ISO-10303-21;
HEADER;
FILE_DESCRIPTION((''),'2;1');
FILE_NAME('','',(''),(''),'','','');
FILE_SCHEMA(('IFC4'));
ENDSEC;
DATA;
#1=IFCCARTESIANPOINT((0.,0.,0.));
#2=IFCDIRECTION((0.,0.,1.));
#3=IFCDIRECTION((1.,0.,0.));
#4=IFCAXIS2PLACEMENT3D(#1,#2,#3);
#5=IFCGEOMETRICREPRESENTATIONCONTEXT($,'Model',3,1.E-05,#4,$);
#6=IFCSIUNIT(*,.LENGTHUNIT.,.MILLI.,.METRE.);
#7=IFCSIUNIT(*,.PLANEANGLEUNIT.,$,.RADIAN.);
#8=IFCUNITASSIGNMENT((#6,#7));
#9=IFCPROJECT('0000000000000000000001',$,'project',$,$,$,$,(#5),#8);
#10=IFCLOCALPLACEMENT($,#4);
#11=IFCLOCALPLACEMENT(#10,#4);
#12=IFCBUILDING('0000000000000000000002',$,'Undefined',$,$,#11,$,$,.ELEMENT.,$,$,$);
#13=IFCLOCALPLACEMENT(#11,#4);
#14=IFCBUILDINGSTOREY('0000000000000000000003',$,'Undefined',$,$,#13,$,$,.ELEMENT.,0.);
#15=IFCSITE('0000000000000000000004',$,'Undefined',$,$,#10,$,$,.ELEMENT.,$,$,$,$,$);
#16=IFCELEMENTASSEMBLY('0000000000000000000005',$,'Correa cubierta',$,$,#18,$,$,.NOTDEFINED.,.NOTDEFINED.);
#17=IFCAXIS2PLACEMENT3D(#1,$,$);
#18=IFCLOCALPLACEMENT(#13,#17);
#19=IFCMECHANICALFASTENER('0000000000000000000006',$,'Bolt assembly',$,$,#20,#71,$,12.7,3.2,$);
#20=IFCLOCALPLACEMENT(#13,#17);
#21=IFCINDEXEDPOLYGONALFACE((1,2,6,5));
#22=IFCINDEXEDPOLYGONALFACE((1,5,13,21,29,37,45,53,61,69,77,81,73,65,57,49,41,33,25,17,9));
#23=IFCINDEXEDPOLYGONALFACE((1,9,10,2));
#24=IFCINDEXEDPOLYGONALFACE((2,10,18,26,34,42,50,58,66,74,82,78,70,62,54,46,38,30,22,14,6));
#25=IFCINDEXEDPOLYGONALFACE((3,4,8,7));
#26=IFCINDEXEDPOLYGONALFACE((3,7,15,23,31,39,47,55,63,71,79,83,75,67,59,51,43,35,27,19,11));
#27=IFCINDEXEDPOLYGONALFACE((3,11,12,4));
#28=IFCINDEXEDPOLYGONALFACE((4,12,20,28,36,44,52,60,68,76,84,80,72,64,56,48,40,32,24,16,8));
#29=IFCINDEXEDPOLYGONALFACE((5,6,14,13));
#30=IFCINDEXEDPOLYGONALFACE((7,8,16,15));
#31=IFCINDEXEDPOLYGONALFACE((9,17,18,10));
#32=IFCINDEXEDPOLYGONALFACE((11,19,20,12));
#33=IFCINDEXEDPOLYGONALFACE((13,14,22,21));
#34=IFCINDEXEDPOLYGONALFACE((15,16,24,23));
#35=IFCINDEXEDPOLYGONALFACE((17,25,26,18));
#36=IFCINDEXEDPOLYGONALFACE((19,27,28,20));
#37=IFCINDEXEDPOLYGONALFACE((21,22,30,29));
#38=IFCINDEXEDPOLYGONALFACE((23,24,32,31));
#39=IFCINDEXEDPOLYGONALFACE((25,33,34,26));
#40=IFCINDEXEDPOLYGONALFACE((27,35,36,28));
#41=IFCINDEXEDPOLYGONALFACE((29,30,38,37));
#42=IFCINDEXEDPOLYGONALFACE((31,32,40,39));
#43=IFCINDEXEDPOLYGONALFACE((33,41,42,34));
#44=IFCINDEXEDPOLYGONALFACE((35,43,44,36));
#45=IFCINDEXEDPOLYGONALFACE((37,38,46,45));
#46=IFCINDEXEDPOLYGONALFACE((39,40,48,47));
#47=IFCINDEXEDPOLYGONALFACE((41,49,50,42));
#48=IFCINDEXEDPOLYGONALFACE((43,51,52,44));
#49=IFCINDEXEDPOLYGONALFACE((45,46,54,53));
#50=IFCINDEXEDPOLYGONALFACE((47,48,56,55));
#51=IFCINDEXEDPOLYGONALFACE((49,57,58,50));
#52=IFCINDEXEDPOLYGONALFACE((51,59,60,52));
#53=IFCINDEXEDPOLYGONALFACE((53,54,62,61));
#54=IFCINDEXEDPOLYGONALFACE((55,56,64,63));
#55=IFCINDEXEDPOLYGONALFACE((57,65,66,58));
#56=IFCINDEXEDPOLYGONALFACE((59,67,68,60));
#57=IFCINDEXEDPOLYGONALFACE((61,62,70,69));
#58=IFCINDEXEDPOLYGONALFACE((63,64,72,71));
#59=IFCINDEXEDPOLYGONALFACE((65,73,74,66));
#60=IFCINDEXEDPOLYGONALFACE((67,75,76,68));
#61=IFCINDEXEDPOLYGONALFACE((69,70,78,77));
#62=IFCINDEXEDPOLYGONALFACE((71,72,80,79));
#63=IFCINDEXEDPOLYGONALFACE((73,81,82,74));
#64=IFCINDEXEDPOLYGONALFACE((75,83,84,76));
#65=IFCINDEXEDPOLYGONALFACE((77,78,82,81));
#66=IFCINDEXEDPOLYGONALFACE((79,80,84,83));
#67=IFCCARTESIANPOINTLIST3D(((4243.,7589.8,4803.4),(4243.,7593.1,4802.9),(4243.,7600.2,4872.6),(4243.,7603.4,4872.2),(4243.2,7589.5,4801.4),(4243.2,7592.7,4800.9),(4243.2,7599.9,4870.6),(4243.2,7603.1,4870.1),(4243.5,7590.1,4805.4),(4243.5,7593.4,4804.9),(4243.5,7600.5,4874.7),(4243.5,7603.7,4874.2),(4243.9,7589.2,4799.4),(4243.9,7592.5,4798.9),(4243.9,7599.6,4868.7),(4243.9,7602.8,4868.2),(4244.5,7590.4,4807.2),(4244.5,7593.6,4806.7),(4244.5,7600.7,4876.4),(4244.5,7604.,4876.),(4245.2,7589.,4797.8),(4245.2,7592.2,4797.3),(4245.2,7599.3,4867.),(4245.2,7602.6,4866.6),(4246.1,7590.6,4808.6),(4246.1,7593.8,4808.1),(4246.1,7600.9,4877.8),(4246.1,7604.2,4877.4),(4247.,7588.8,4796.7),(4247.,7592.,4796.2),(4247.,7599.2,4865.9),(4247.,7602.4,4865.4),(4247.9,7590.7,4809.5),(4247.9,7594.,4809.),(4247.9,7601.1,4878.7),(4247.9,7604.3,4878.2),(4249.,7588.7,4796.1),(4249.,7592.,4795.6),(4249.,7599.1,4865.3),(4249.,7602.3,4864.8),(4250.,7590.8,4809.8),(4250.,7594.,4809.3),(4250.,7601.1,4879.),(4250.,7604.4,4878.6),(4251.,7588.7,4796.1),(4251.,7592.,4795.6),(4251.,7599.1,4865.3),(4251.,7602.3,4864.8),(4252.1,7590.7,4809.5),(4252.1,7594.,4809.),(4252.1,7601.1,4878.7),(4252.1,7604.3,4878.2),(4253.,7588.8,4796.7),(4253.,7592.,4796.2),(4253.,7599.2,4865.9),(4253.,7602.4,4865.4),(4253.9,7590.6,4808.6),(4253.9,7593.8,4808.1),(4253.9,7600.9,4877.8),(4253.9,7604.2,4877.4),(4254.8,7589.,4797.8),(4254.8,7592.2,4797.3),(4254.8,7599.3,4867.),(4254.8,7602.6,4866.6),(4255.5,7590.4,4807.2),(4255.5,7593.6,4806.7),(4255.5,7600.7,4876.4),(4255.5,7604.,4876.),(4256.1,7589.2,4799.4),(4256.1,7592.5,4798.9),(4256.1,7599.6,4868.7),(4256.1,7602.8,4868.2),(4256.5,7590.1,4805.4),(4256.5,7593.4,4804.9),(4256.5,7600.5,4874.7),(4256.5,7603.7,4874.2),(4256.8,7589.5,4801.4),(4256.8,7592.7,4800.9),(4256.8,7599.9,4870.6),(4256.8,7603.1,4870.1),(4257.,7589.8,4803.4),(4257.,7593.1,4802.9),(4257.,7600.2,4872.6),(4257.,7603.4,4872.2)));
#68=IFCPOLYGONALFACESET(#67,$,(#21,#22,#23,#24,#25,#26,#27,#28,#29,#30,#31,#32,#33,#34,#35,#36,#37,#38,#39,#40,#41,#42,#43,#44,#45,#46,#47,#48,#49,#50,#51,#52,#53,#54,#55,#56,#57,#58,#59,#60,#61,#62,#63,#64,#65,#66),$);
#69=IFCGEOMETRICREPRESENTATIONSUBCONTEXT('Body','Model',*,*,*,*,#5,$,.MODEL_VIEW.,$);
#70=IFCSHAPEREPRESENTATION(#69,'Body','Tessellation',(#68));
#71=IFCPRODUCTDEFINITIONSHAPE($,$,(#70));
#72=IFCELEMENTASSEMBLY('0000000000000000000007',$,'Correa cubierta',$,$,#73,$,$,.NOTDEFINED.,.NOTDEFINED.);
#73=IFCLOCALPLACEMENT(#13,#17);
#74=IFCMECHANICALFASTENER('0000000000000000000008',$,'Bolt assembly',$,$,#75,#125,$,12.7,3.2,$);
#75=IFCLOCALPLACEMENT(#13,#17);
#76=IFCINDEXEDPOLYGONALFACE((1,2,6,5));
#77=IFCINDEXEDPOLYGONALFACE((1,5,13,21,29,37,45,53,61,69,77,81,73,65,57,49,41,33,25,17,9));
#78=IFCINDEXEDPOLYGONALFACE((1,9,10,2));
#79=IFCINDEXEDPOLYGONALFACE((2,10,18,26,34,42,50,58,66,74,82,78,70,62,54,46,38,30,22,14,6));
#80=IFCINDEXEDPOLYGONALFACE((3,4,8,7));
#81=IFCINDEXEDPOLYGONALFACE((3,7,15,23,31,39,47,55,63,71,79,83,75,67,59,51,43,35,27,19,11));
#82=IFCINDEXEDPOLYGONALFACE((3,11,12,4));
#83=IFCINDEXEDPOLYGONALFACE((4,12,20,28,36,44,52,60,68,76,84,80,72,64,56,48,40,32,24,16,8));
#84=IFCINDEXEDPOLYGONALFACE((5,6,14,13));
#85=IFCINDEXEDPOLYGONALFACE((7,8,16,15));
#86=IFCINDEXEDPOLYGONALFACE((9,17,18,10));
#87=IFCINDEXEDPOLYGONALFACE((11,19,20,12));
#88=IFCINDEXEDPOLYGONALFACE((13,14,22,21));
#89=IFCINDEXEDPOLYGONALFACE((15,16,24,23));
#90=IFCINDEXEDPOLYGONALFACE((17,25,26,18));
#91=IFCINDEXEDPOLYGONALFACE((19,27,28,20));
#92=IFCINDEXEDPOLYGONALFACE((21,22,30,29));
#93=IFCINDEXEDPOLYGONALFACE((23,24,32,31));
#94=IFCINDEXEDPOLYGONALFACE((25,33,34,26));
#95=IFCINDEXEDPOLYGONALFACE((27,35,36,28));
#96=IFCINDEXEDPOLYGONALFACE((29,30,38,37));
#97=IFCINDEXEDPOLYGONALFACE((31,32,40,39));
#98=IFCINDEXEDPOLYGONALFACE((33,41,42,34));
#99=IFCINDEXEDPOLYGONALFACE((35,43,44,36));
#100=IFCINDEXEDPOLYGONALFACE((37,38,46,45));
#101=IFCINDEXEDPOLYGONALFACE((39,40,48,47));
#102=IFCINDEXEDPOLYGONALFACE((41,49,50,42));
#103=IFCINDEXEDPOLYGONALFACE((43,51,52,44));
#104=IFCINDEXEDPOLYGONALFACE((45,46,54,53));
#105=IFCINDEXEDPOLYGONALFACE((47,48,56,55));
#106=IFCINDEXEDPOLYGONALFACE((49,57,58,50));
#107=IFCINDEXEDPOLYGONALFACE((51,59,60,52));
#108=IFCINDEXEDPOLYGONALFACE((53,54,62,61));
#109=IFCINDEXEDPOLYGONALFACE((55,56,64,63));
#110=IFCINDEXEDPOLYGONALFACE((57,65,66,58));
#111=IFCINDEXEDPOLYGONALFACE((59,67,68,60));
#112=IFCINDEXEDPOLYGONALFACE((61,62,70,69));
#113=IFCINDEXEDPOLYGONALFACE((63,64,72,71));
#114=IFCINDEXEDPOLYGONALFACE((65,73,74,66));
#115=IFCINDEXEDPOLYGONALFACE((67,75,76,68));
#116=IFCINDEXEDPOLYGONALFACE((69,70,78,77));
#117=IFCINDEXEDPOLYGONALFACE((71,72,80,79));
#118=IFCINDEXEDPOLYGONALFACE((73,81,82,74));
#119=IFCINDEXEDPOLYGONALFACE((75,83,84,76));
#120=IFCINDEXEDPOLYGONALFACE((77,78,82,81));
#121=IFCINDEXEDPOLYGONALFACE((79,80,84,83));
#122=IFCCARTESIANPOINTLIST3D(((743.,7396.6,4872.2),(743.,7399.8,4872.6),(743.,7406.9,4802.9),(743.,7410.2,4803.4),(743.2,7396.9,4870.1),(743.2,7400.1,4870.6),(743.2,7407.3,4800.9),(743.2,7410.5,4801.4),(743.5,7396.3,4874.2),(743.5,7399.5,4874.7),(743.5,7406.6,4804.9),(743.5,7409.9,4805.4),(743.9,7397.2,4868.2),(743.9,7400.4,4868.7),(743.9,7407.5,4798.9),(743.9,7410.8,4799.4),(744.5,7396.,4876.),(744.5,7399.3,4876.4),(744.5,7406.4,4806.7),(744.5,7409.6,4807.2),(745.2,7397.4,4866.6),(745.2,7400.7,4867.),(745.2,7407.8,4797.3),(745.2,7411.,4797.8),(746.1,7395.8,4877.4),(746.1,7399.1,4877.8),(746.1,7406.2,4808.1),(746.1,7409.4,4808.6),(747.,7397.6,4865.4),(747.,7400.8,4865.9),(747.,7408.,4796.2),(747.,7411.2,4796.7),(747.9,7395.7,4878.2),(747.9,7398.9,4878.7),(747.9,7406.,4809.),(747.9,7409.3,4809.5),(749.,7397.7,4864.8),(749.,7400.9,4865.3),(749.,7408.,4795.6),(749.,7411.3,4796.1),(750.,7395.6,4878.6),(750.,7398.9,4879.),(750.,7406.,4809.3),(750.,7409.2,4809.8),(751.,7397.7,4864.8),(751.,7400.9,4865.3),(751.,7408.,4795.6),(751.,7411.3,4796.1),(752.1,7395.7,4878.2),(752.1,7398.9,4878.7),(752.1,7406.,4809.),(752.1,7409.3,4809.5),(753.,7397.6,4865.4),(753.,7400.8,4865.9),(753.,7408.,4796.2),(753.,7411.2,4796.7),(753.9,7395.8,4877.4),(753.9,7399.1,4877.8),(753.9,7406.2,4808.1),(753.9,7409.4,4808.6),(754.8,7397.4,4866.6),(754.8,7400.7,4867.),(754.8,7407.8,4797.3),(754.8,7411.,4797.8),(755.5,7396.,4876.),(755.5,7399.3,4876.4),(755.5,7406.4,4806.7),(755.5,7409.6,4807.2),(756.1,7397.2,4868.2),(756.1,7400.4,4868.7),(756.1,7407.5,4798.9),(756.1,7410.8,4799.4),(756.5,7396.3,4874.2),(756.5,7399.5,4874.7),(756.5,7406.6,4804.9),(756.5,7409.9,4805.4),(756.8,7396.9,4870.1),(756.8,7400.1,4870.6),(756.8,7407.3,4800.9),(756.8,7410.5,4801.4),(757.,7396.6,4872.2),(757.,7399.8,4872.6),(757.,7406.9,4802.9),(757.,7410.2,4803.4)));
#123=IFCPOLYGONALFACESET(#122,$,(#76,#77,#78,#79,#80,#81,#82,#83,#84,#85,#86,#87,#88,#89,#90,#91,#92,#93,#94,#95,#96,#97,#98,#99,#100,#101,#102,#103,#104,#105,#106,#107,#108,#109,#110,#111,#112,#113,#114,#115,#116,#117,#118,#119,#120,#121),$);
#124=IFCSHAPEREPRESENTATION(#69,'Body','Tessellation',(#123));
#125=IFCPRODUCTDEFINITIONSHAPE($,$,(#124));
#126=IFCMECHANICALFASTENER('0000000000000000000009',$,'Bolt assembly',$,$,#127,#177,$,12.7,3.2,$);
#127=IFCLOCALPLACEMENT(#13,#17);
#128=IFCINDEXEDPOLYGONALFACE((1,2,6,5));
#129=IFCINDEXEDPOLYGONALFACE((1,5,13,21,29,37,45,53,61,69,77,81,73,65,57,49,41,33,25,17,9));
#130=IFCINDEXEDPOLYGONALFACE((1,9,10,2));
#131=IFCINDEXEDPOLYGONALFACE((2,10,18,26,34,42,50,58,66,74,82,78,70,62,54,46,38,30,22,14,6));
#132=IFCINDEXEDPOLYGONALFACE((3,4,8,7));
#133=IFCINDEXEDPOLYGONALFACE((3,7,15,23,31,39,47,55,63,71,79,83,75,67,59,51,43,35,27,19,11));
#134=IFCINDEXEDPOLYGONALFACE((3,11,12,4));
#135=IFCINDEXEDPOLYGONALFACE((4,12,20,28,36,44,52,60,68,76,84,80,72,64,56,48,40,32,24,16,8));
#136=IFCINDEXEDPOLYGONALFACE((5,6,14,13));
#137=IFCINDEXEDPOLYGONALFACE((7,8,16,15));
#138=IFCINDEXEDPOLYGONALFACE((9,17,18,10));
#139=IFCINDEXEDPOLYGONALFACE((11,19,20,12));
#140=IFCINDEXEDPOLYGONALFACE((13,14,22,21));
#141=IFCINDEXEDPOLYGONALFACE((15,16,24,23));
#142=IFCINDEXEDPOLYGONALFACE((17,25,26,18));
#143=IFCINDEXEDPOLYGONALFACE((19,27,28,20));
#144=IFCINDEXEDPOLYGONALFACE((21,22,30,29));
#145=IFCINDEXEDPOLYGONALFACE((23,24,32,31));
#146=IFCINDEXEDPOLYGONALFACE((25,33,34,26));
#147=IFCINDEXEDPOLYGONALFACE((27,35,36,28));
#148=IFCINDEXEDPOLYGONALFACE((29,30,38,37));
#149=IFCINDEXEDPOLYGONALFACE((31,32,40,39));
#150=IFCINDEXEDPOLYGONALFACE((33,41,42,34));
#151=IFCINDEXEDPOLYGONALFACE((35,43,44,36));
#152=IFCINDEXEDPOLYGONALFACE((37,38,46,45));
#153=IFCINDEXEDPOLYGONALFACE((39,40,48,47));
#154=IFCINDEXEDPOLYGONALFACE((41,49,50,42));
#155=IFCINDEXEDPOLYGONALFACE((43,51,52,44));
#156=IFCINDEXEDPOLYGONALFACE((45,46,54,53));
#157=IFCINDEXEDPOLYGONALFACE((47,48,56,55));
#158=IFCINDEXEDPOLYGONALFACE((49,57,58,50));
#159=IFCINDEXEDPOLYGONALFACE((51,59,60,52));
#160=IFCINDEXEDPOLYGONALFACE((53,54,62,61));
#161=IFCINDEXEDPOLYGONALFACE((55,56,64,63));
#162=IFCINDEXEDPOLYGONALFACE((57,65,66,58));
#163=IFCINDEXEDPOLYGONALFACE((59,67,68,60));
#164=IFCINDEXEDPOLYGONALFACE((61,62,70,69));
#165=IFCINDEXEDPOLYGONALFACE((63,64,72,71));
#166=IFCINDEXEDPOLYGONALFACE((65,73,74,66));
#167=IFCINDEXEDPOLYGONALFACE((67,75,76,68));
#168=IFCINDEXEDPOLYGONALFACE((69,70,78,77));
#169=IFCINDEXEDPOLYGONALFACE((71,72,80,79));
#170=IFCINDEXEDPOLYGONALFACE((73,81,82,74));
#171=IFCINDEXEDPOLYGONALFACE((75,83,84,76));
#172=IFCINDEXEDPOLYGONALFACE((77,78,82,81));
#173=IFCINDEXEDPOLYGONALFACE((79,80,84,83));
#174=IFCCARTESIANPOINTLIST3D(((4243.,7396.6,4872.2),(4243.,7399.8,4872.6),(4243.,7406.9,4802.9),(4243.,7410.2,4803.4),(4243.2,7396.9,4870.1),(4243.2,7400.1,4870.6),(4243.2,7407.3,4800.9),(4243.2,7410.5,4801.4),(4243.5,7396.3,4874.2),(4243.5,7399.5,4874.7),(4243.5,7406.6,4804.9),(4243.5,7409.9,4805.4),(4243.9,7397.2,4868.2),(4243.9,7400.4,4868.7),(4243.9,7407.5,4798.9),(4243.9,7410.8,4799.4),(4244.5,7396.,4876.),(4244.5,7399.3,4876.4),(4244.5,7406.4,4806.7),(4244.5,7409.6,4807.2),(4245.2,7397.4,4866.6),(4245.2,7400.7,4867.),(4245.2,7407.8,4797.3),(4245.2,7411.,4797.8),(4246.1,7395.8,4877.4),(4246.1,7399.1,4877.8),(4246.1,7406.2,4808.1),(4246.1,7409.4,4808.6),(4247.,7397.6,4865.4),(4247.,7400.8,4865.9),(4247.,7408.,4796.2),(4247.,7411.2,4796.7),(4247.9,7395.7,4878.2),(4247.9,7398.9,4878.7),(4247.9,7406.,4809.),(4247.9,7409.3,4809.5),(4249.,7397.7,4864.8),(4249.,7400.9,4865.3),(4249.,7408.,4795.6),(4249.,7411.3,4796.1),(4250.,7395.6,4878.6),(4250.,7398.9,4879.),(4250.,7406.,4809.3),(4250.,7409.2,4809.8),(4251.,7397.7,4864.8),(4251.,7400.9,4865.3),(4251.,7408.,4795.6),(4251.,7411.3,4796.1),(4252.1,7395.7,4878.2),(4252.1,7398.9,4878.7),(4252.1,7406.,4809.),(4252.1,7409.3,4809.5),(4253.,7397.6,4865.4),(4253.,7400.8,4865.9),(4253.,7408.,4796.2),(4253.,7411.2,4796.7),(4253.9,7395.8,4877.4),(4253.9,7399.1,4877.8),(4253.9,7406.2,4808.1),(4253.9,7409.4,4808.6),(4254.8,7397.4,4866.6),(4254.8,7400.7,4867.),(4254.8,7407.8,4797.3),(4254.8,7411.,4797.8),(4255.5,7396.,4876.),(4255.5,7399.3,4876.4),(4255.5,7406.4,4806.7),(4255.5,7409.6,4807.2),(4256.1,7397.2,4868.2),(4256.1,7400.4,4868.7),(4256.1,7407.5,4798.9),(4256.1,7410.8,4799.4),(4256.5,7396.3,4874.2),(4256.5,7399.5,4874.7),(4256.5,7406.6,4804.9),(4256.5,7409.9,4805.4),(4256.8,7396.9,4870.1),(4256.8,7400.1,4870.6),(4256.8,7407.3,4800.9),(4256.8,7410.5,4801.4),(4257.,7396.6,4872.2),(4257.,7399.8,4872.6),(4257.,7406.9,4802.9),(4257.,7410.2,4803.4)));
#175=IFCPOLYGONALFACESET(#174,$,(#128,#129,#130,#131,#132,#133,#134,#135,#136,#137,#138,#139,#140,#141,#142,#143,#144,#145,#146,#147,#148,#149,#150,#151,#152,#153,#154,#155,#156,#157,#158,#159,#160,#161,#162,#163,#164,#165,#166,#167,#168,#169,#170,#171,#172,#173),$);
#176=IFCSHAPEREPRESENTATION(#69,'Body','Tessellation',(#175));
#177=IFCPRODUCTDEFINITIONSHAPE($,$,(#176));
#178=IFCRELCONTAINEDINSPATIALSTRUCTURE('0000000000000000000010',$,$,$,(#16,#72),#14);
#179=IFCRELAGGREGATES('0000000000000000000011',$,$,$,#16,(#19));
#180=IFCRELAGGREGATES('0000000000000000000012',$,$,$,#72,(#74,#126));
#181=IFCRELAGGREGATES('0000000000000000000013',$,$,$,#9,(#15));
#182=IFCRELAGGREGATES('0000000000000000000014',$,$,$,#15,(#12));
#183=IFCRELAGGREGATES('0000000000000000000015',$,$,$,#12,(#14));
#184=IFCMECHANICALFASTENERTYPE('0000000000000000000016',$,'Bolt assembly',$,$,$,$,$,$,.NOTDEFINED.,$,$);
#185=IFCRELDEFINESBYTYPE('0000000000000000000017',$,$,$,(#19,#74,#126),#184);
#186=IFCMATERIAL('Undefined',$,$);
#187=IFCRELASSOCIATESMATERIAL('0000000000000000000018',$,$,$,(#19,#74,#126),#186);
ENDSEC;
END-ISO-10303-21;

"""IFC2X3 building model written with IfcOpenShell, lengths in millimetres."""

from ifc_helpers import new_model, si_unit, frame, origin_with_axes, origin_2d_with_axis, place, context, subcontext, project, spatial, circle, extrude, source, transform, mapped, material, type_object, element, aggregate, save


model = new_model("IFC2X3")

# Units and contexts
model_context = context("Model", 3, precision=1e-05, world=origin_with_axes())
body_context = subcontext(model_context, "Body", "Model", "MODEL_VIEW")
ifc_project = project(units=[si_unit("LENGTHUNIT", "METRE", prefix="MILLI"), si_unit("PLANEANGLEUNIT", "RADIAN")], contexts=[model_context])

# Site, building, storey
site_placement = place(None, origin_with_axes())
site = spatial("IfcSite", under=ifc_project, at=site_placement, Name="Undefined", CompositionType="ELEMENT")
building_placement = place(site_placement, origin_with_axes())
building = spatial("IfcBuilding", under=site, at=building_placement, Name="Undefined", CompositionType="ELEMENT")
storey_placement = place(building_placement, origin_with_axes())
storey = spatial("IfcBuildingStorey", under=building, at=storey_placement, Name="Undefined", CompositionType="ELEMENT", Elevation=0.0)

# Shared definitions
ifc_material_1 = material(Name="Undefined")
mechanical_fastener_type = type_object("IfcMechanicalFastenerType", Name="Bolt assembly")

# Element assemblies, mechanical fasteners
assembly_1_placement = place(storey_placement, origin_with_axes())
assembly_1 = element("IfcElementAssembly", 1, at=assembly_1_placement, inside=storey, Name="Correa cubierta", AssemblyPlace="NOTDEFINED", PredefinedType="NOTDEFINED")
shared_shape_1 = source(origin_with_axes(), body_context, "Body", "SweptSolid", [
    extrude(circle(Radius=7.0, at=origin_2d_with_axis()), frame((0.0, 3.2, 0.0), z_axis=(0.0, 1.0, 0.0), x_axis=(1.0, 0.0, 0.0)), (0.0, 0.0, 1.0), 3.3),
])
mechanical_fastener_1_placement = place(assembly_1_placement, frame((4250.0, 7586.6, 4803.4), z_axis=(-1.0, 0.0, 0.0), x_axis=(0.0, 0.148209, 0.988956)))
mechanical_fastener_1 = element("IfcMechanicalFastener", 2, at=mechanical_fastener_1_placement, type_object=mechanical_fastener_type, material=ifc_material_1, Name="Bolt assembly", NominalDiameter=12.7, NominalLength=3.2, context=body_context, shape_type="MappedRepresentation", body=[
    mapped(shared_shape_1, transform((0.0, 0.0, 0.0))),
    mapped(shared_shape_1, transform((70.0, 0.0, 0.0))),
])
aggregate(assembly_1, [mechanical_fastener_1])
assembly_2_placement = place(storey_placement, origin_with_axes())
assembly_2 = element("IfcElementAssembly", 3, at=assembly_2_placement, inside=storey, Name="Correa cubierta", AssemblyPlace="NOTDEFINED", PredefinedType="NOTDEFINED")
mechanical_fastener_2_placement = place(assembly_2_placement, frame((750.0, 7413.4, 4803.4), z_axis=(1.0, 0.0, 0.0), x_axis=(0.0, -0.148209, 0.988956)))
mechanical_fastener_2 = element("IfcMechanicalFastener", 4, at=mechanical_fastener_2_placement, type_object=mechanical_fastener_type, material=ifc_material_1, Name="Bolt assembly", NominalDiameter=12.7, NominalLength=3.2, context=body_context, shape_type="MappedRepresentation", body=[
    mapped(shared_shape_1, transform((0.0, 0.0, 0.0))),
    mapped(shared_shape_1, transform((70.0, 0.0, 0.0))),
])
mechanical_fastener_3_placement = place(assembly_2_placement, frame((4250.0, 7413.4, 4803.4), z_axis=(1.0, 0.0, 0.0), x_axis=(0.0, -0.148209, 0.988956)))
mechanical_fastener_3 = element("IfcMechanicalFastener", 5, at=mechanical_fastener_3_placement, type_object=mechanical_fastener_type, material=ifc_material_1, Name="Bolt assembly", NominalDiameter=12.7, NominalLength=3.2, context=body_context, shape_type="MappedRepresentation", body=[
    mapped(shared_shape_1, transform((0.0, 0.0, 0.0))),
    mapped(shared_shape_1, transform((70.0, 0.0, 0.0))),
])
aggregate(assembly_2, [mechanical_fastener_2, mechanical_fastener_3])

save(model, "model.ifc")
